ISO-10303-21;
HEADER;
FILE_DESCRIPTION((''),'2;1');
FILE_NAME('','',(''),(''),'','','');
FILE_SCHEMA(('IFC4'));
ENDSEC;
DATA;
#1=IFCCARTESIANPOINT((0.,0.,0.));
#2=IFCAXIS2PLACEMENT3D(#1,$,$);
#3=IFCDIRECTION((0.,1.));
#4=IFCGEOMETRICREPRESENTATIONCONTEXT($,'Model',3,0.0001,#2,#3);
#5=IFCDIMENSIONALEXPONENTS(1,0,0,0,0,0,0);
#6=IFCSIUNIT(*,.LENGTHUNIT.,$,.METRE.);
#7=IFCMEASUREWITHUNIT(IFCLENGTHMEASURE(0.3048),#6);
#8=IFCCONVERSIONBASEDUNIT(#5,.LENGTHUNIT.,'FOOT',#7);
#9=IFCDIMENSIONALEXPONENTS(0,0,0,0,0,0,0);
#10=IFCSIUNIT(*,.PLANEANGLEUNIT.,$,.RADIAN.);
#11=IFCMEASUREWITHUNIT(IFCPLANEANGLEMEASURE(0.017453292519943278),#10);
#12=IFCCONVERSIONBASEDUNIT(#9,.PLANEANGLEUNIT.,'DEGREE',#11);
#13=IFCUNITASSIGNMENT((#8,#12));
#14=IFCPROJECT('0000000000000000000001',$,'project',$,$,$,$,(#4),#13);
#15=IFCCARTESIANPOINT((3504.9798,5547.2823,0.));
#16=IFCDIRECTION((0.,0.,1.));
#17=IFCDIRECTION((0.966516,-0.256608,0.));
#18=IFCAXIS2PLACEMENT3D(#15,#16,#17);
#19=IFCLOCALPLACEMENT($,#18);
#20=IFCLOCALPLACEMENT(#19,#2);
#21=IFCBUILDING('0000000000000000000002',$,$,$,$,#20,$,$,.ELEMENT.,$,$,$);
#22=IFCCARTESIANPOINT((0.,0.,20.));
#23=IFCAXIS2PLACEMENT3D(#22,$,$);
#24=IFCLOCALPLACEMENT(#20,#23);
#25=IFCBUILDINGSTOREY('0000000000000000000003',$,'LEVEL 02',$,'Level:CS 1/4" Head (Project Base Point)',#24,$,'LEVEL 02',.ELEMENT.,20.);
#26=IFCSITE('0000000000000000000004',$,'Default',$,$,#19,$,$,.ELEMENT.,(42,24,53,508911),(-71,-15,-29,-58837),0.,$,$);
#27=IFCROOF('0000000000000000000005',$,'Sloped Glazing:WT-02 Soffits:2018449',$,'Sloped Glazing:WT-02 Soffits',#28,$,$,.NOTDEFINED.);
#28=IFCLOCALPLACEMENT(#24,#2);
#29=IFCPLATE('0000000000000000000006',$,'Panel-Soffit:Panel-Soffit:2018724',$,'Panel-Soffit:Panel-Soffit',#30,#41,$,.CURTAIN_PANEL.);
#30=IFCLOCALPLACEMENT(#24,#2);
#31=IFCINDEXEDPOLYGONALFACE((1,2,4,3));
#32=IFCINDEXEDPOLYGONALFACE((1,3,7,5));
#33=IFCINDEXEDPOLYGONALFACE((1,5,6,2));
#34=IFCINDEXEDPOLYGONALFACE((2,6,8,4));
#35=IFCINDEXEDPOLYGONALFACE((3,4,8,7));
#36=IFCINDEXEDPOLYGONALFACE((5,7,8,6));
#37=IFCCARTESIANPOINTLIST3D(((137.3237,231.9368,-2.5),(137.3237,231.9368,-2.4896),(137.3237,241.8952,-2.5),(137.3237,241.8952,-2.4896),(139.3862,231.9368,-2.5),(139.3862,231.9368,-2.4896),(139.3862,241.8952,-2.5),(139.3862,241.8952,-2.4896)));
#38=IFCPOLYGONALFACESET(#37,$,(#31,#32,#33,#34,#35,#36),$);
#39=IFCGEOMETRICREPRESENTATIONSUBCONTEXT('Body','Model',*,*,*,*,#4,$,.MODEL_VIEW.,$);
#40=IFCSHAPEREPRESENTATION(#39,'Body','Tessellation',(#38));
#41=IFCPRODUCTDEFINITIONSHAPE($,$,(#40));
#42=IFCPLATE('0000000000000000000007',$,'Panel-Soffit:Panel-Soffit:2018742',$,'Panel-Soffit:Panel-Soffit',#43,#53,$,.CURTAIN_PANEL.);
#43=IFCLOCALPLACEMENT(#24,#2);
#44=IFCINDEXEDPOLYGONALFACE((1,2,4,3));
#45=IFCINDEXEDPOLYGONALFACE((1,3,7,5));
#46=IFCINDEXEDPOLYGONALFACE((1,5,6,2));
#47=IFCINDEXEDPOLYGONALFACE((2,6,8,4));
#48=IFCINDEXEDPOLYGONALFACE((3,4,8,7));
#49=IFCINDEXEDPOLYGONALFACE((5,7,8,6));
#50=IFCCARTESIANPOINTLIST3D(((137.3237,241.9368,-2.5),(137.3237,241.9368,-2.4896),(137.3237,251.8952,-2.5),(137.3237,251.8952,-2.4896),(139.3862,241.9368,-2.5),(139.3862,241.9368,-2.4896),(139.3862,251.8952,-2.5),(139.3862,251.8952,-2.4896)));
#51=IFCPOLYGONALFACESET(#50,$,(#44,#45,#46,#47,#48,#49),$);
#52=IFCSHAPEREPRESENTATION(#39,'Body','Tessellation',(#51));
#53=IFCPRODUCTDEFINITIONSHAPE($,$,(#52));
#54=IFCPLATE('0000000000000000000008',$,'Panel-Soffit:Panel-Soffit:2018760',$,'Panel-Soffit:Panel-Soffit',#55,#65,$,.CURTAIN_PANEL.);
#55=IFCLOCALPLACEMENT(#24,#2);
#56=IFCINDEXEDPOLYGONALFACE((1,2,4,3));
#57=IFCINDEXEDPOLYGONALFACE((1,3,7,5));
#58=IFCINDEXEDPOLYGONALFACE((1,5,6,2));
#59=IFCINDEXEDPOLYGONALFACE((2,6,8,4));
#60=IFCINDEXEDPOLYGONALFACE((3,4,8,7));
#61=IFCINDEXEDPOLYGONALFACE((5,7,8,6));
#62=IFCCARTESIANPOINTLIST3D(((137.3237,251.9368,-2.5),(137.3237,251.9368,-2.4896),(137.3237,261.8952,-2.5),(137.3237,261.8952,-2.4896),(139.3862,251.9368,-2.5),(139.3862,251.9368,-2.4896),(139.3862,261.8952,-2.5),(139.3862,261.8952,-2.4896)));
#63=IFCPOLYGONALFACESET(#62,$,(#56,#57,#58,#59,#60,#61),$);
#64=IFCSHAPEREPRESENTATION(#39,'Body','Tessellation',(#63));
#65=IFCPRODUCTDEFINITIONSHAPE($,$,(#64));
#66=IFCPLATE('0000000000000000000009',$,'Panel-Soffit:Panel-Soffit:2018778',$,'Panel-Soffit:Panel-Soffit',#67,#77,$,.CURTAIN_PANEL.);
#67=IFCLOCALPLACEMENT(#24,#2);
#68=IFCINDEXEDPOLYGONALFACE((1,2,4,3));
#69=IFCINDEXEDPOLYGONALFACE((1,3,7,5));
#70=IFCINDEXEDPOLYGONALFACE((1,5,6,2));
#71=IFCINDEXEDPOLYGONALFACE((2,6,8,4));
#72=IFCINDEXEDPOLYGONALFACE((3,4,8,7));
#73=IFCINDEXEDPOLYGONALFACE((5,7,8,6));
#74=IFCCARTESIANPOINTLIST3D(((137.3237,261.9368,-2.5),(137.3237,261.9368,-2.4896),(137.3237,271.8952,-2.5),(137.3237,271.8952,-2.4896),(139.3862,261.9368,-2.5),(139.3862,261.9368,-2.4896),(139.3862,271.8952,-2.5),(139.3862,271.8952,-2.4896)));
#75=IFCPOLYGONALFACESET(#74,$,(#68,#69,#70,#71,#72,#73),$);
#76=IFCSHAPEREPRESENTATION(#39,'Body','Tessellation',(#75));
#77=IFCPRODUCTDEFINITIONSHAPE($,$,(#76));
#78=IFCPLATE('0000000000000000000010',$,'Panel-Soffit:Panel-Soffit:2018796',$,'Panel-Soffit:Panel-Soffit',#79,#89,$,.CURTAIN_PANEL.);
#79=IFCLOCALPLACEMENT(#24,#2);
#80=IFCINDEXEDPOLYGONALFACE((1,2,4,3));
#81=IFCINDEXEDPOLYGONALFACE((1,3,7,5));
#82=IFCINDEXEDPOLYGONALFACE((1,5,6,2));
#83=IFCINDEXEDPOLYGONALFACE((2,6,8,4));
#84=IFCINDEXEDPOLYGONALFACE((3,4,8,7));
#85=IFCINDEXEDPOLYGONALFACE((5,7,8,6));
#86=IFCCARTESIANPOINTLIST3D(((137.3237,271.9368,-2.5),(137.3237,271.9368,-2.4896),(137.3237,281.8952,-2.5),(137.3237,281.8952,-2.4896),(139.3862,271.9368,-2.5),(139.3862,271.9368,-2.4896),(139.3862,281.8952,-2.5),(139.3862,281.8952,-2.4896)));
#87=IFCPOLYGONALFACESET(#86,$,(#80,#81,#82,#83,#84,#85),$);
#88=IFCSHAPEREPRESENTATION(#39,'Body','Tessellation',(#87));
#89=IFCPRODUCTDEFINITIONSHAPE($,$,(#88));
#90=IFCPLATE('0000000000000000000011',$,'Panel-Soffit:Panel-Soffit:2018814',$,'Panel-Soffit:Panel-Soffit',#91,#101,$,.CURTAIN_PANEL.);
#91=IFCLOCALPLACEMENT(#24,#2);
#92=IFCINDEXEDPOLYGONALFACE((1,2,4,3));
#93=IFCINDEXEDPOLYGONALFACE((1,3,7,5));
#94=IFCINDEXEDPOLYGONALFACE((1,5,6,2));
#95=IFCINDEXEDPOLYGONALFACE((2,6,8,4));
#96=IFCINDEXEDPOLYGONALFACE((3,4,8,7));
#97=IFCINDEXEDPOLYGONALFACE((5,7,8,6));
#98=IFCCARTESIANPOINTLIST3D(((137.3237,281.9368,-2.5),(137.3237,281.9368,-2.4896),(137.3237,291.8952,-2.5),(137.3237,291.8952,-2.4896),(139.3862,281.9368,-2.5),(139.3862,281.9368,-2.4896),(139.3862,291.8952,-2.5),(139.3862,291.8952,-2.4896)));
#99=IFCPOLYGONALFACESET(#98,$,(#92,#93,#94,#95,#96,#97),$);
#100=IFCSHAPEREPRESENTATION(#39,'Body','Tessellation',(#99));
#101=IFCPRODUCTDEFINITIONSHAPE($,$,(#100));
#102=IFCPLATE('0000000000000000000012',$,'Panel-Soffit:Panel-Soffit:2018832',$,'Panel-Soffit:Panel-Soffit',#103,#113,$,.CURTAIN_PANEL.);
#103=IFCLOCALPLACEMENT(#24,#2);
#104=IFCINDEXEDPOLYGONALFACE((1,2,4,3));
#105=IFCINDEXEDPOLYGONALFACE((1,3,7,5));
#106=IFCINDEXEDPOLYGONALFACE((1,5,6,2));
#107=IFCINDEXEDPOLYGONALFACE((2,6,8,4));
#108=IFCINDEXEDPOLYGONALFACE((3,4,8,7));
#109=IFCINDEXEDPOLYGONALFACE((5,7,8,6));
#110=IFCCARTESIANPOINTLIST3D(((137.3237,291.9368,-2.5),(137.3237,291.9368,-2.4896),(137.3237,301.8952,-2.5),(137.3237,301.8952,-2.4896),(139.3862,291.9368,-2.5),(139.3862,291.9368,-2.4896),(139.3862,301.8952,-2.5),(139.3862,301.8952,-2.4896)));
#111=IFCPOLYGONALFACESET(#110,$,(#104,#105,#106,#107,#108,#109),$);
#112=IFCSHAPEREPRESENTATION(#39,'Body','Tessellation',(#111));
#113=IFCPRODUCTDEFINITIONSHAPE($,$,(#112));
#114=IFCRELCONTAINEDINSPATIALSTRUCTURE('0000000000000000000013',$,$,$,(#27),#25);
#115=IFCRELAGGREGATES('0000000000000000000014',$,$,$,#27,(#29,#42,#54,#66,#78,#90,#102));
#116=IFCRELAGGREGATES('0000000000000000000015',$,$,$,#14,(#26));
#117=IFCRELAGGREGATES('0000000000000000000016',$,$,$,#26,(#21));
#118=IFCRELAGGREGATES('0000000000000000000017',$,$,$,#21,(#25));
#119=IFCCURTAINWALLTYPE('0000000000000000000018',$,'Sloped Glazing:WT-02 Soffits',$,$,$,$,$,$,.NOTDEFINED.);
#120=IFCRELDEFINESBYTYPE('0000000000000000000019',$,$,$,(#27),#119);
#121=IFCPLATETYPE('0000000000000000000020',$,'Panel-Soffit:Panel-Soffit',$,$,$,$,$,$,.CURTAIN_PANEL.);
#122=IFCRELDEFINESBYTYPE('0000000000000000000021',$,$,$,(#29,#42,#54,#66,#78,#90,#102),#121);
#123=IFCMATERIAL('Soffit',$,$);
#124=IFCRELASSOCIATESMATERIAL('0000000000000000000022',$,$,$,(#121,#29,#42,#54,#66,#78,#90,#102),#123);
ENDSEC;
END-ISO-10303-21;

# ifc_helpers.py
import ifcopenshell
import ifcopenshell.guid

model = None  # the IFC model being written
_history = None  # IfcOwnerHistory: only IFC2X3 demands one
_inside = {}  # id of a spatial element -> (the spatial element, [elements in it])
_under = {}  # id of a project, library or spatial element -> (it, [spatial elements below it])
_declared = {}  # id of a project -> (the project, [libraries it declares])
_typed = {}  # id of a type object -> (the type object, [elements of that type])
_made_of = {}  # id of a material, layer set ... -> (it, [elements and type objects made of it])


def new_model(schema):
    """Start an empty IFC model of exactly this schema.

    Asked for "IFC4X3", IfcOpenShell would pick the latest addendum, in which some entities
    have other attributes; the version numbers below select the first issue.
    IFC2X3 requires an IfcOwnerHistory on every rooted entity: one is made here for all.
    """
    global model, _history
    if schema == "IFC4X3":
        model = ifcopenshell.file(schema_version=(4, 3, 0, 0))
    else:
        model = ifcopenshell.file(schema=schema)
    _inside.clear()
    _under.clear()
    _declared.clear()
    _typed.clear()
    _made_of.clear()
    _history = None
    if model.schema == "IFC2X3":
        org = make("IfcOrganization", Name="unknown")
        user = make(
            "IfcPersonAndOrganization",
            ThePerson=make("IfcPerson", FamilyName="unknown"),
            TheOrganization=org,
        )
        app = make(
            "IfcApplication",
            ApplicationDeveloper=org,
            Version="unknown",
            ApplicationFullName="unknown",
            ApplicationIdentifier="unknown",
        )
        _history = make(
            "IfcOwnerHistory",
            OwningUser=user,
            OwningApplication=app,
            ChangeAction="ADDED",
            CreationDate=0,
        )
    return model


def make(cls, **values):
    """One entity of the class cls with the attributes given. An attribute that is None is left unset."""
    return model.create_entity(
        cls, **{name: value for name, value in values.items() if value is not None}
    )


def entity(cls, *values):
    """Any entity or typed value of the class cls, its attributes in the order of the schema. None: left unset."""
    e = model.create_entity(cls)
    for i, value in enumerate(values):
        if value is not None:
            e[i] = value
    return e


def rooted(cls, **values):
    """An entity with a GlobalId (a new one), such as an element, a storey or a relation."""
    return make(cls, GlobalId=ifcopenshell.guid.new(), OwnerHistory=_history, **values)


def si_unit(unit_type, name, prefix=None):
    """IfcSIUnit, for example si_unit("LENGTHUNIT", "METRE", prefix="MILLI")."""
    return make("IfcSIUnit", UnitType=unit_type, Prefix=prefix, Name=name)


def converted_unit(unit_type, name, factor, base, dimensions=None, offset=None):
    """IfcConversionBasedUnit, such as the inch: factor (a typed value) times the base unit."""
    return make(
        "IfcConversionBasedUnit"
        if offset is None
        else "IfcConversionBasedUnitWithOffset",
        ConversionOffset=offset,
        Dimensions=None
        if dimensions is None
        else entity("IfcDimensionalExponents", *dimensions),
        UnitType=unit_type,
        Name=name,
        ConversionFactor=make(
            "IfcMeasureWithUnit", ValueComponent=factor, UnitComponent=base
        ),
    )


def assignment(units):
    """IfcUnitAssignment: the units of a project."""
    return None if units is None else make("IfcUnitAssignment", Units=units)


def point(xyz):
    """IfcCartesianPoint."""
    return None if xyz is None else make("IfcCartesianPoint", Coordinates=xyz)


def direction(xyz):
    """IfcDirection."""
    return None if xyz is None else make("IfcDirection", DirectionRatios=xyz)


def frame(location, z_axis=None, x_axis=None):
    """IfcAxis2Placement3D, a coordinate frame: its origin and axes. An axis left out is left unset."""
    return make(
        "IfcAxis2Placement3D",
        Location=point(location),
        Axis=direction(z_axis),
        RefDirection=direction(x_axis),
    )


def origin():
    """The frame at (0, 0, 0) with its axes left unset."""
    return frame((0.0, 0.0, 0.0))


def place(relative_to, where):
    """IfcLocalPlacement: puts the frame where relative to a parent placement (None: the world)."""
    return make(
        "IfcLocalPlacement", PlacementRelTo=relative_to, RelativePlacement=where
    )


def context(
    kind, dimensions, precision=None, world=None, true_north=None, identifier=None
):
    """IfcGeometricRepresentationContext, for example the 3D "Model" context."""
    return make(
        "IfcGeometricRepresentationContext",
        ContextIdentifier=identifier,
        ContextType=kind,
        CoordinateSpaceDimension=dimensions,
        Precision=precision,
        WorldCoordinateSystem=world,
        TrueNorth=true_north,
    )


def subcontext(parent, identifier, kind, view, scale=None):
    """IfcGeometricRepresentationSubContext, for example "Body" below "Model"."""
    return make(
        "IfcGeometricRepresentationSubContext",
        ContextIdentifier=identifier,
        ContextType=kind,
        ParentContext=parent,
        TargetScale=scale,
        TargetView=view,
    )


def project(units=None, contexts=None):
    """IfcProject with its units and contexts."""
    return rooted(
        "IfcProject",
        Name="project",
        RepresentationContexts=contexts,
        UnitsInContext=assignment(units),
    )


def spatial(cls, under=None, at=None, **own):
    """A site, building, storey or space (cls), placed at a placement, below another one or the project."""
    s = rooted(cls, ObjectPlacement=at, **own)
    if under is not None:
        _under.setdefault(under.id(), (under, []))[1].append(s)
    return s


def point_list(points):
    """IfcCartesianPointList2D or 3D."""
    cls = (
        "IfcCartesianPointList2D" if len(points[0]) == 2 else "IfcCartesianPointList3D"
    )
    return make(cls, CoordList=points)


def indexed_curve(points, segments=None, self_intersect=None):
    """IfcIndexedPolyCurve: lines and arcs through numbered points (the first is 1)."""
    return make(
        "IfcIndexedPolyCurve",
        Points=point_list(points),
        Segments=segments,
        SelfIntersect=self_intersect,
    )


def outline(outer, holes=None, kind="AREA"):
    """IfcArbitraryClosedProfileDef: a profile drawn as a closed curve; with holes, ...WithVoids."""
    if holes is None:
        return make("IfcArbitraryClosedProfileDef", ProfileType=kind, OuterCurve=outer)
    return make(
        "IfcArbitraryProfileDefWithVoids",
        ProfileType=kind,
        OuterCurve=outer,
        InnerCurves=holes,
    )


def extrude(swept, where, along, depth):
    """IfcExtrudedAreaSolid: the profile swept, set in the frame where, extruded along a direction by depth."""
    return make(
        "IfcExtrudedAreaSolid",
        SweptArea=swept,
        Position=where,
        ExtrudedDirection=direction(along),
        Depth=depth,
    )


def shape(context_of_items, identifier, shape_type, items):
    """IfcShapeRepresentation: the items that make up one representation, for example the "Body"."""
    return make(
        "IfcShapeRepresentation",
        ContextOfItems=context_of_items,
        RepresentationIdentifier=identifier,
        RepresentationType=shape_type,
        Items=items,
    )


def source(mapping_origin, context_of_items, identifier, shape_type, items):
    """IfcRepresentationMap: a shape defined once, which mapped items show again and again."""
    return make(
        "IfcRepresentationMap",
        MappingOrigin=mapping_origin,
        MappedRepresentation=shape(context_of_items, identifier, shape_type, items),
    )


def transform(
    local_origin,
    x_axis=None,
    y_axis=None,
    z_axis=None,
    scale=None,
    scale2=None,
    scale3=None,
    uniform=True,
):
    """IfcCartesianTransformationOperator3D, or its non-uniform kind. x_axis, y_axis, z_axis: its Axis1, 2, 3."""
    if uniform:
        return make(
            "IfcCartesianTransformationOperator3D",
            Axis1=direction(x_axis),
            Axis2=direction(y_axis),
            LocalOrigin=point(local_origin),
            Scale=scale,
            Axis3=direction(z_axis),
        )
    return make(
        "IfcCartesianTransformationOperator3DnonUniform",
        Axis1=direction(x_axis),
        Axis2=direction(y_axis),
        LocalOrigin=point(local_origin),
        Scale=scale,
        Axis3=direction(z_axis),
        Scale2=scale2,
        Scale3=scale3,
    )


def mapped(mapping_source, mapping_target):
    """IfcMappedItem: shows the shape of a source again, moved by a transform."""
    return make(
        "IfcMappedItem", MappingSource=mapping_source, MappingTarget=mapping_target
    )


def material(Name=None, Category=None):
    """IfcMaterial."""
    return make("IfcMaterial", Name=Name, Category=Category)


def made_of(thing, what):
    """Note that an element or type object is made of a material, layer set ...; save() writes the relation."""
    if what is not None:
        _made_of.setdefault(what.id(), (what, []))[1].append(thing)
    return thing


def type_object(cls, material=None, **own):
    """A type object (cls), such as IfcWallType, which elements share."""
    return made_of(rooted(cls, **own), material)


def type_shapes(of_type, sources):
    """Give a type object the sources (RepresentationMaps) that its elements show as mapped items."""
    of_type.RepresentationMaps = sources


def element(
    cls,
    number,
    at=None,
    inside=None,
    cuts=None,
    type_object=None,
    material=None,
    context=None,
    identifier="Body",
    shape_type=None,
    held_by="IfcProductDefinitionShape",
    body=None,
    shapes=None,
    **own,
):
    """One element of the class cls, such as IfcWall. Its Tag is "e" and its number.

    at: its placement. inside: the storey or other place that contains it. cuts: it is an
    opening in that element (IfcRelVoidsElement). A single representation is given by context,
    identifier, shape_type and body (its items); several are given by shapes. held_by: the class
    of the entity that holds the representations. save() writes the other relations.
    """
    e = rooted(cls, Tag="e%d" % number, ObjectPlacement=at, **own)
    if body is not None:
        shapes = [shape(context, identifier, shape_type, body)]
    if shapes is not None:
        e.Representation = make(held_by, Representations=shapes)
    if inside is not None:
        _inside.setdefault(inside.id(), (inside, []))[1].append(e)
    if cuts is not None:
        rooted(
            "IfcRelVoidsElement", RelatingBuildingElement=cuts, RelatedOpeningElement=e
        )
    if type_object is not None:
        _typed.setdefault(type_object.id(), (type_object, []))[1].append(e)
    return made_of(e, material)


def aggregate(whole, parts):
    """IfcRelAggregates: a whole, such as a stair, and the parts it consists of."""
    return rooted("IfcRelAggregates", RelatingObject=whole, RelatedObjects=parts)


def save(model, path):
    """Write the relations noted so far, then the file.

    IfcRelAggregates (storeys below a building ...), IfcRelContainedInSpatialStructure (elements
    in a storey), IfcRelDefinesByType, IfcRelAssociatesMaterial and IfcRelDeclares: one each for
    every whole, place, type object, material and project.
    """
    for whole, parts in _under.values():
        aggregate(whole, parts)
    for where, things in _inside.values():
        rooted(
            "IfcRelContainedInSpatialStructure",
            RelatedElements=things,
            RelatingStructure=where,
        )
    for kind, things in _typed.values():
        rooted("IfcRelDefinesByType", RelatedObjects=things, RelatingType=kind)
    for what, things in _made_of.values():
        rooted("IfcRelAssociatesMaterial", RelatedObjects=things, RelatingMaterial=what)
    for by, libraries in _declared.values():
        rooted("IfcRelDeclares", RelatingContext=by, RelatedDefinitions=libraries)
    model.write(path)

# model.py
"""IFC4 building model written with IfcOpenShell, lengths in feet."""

from ifc_helpers import new_model, entity, si_unit, converted_unit, direction, frame, origin, place, context, subcontext, project, spatial, indexed_curve, outline, extrude, source, transform, mapped, material, type_object, type_shapes, element, aggregate, save


model = new_model("IFC4")

# Units and contexts
model_context = context("Model", 3, precision=0.0001, world=origin(), true_north=direction((0.0, 1.0)))
body_context = subcontext(model_context, "Body", "Model", "MODEL_VIEW")
ifc_project = project(units=[converted_unit("LENGTHUNIT", "FOOT", entity("IfcLengthMeasure", 0.3048), si_unit("LENGTHUNIT", "METRE"), dimensions=[1, 0, 0, 0, 0, 0, 0]), converted_unit("PLANEANGLEUNIT", "DEGREE", entity("IfcPlaneAngleMeasure", 0.017453292519943278), si_unit("PLANEANGLEUNIT", "RADIAN"), dimensions=[0, 0, 0, 0, 0, 0, 0])], contexts=[model_context])

# Site, building, storey
site_placement = place(None, frame((3504.9798, 5547.2823, 0.0), z_axis=(0.0, 0.0, 1.0), x_axis=(0.966516, -0.256608, 0.0)))
site = spatial("IfcSite", under=ifc_project, at=site_placement, Name="Default", CompositionType="ELEMENT", RefLatitude=(42, 24, 53, 508911), RefLongitude=(-71, -15, -29, -58837), RefElevation=0.0)
building_placement = place(site_placement, origin())
building = spatial("IfcBuilding", under=site, at=building_placement, CompositionType="ELEMENT")
storey_placement = place(building_placement, frame((0.0, 0.0, 20.0)))
storey = spatial("IfcBuildingStorey", under=building, at=storey_placement, Name="LEVEL 02", ObjectType="Level:CS 1/4\" Head (Project Base Point)", LongName="LEVEL 02", CompositionType="ELEMENT", Elevation=20.0)

# Roof, plates
curtain_wall_type_1 = type_object("IfcCurtainWallType", Name="Sloped Glazing:WT-02 Soffits", PredefinedType="NOTDEFINED")
roof_1_placement = place(storey_placement, frame((0.0, 0.0, -20.0)))
roof_1 = element("IfcRoof", 1, at=roof_1_placement, inside=storey, type_object=curtain_wall_type_1, Name="Sloped Glazing:WT-02 Soffits:2018449", ObjectType="Sloped Glazing:WT-02 Soffits", PredefinedType="NOTDEFINED")
ifc_material_1 = material(Name="Soffit")
plate_type_1 = type_object("IfcPlateType", Name="Panel-Soffit:Panel-Soffit", PredefinedType="CURTAIN_PANEL", material=ifc_material_1)
shared_shape_1 = source(origin(), body_context, "Body", "SweptSolid", [
    extrude(outline(indexed_curve([(-0.0052, -1.0313), (0.0052, -1.0313), (0.0052, 1.0313), (-0.0052, 1.0313), (-0.0052, -1.0313)], self_intersect=False)), frame((0.0, -0.0052, 0.0208), z_axis=(0.0, 0.0, 1.0), x_axis=(0.0, -1.0, 0.0)), (0.0, 0.0, 1.0), 9.9583),
])
type_shapes(plate_type_1, [shared_shape_1])
plate_1_placement = place(roof_1_placement, frame((138.355, 231.916, 17.5), z_axis=(0.0, 1.0, 0.0), x_axis=(1.0, 0.0, 0.0)))
plate_1 = element("IfcPlate", 2, at=plate_1_placement, type_object=plate_type_1, material=ifc_material_1, Name="Panel-Soffit:Panel-Soffit:2018724", ObjectType="Panel-Soffit:Panel-Soffit", PredefinedType="CURTAIN_PANEL", context=body_context, shape_type="MappedRepresentation", body=[
    mapped(shared_shape_1, transform((0.0, 0.0, 0.0), scale=1.0)),
])
plate_2_placement = place(roof_1_placement, frame((138.355, 241.916, 17.5), z_axis=(0.0, 1.0, 0.0), x_axis=(1.0, 0.0, 0.0)))
plate_2 = element("IfcPlate", 3, at=plate_2_placement, type_object=plate_type_1, material=ifc_material_1, Name="Panel-Soffit:Panel-Soffit:2018742", ObjectType="Panel-Soffit:Panel-Soffit", PredefinedType="CURTAIN_PANEL", context=body_context, shape_type="MappedRepresentation", body=[
    mapped(shared_shape_1, transform((0.0, 0.0, 0.0), scale=1.0)),
])
plate_3_placement = place(roof_1_placement, frame((138.355, 251.916, 17.5), z_axis=(0.0, 1.0, 0.0), x_axis=(1.0, 0.0, 0.0)))
plate_3 = element("IfcPlate", 4, at=plate_3_placement, type_object=plate_type_1, material=ifc_material_1, Name="Panel-Soffit:Panel-Soffit:2018760", ObjectType="Panel-Soffit:Panel-Soffit", PredefinedType="CURTAIN_PANEL", context=body_context, shape_type="MappedRepresentation", body=[
    mapped(shared_shape_1, transform((0.0, 0.0, 0.0), scale=1.0)),
])
plate_4_placement = place(roof_1_placement, frame((138.355, 261.916, 17.5), z_axis=(0.0, 1.0, 0.0), x_axis=(1.0, 0.0, 0.0)))
plate_4 = element("IfcPlate", 5, at=plate_4_placement, type_object=plate_type_1, material=ifc_material_1, Name="Panel-Soffit:Panel-Soffit:2018778", ObjectType="Panel-Soffit:Panel-Soffit", PredefinedType="CURTAIN_PANEL", context=body_context, shape_type="MappedRepresentation", body=[
    mapped(shared_shape_1, transform((0.0, 0.0, 0.0), scale=1.0)),
])
plate_5_placement = place(roof_1_placement, frame((138.355, 271.916, 17.5), z_axis=(0.0, 1.0, 0.0), x_axis=(1.0, 0.0, 0.0)))
plate_5 = element("IfcPlate", 6, at=plate_5_placement, type_object=plate_type_1, material=ifc_material_1, Name="Panel-Soffit:Panel-Soffit:2018796", ObjectType="Panel-Soffit:Panel-Soffit", PredefinedType="CURTAIN_PANEL", context=body_context, shape_type="MappedRepresentation", body=[
    mapped(shared_shape_1, transform((0.0, 0.0, 0.0), scale=1.0)),
])
plate_6_placement = place(roof_1_placement, frame((138.355, 281.916, 17.5), z_axis=(0.0, 1.0, 0.0), x_axis=(1.0, 0.0, 0.0)))
plate_6 = element("IfcPlate", 7, at=plate_6_placement, type_object=plate_type_1, material=ifc_material_1, Name="Panel-Soffit:Panel-Soffit:2018814", ObjectType="Panel-Soffit:Panel-Soffit", PredefinedType="CURTAIN_PANEL", context=body_context, shape_type="MappedRepresentation", body=[
    mapped(shared_shape_1, transform((0.0, 0.0, 0.0), scale=1.0)),
])
plate_7_placement = place(roof_1_placement, frame((138.355, 291.916, 17.5), z_axis=(0.0, 1.0, 0.0), x_axis=(1.0, 0.0, 0.0)))
plate_7 = element("IfcPlate", 8, at=plate_7_placement, type_object=plate_type_1, material=ifc_material_1, Name="Panel-Soffit:Panel-Soffit:2018832", ObjectType="Panel-Soffit:Panel-Soffit", PredefinedType="CURTAIN_PANEL", context=body_context, shape_type="MappedRepresentation", body=[
    mapped(shared_shape_1, transform((0.0, 0.0, 0.0), scale=1.0)),
])
aggregate(roof_1, [plate_1, plate_2, plate_3, plate_4, plate_5, plate_6, plate_7])

save(model, "model.ifc")
